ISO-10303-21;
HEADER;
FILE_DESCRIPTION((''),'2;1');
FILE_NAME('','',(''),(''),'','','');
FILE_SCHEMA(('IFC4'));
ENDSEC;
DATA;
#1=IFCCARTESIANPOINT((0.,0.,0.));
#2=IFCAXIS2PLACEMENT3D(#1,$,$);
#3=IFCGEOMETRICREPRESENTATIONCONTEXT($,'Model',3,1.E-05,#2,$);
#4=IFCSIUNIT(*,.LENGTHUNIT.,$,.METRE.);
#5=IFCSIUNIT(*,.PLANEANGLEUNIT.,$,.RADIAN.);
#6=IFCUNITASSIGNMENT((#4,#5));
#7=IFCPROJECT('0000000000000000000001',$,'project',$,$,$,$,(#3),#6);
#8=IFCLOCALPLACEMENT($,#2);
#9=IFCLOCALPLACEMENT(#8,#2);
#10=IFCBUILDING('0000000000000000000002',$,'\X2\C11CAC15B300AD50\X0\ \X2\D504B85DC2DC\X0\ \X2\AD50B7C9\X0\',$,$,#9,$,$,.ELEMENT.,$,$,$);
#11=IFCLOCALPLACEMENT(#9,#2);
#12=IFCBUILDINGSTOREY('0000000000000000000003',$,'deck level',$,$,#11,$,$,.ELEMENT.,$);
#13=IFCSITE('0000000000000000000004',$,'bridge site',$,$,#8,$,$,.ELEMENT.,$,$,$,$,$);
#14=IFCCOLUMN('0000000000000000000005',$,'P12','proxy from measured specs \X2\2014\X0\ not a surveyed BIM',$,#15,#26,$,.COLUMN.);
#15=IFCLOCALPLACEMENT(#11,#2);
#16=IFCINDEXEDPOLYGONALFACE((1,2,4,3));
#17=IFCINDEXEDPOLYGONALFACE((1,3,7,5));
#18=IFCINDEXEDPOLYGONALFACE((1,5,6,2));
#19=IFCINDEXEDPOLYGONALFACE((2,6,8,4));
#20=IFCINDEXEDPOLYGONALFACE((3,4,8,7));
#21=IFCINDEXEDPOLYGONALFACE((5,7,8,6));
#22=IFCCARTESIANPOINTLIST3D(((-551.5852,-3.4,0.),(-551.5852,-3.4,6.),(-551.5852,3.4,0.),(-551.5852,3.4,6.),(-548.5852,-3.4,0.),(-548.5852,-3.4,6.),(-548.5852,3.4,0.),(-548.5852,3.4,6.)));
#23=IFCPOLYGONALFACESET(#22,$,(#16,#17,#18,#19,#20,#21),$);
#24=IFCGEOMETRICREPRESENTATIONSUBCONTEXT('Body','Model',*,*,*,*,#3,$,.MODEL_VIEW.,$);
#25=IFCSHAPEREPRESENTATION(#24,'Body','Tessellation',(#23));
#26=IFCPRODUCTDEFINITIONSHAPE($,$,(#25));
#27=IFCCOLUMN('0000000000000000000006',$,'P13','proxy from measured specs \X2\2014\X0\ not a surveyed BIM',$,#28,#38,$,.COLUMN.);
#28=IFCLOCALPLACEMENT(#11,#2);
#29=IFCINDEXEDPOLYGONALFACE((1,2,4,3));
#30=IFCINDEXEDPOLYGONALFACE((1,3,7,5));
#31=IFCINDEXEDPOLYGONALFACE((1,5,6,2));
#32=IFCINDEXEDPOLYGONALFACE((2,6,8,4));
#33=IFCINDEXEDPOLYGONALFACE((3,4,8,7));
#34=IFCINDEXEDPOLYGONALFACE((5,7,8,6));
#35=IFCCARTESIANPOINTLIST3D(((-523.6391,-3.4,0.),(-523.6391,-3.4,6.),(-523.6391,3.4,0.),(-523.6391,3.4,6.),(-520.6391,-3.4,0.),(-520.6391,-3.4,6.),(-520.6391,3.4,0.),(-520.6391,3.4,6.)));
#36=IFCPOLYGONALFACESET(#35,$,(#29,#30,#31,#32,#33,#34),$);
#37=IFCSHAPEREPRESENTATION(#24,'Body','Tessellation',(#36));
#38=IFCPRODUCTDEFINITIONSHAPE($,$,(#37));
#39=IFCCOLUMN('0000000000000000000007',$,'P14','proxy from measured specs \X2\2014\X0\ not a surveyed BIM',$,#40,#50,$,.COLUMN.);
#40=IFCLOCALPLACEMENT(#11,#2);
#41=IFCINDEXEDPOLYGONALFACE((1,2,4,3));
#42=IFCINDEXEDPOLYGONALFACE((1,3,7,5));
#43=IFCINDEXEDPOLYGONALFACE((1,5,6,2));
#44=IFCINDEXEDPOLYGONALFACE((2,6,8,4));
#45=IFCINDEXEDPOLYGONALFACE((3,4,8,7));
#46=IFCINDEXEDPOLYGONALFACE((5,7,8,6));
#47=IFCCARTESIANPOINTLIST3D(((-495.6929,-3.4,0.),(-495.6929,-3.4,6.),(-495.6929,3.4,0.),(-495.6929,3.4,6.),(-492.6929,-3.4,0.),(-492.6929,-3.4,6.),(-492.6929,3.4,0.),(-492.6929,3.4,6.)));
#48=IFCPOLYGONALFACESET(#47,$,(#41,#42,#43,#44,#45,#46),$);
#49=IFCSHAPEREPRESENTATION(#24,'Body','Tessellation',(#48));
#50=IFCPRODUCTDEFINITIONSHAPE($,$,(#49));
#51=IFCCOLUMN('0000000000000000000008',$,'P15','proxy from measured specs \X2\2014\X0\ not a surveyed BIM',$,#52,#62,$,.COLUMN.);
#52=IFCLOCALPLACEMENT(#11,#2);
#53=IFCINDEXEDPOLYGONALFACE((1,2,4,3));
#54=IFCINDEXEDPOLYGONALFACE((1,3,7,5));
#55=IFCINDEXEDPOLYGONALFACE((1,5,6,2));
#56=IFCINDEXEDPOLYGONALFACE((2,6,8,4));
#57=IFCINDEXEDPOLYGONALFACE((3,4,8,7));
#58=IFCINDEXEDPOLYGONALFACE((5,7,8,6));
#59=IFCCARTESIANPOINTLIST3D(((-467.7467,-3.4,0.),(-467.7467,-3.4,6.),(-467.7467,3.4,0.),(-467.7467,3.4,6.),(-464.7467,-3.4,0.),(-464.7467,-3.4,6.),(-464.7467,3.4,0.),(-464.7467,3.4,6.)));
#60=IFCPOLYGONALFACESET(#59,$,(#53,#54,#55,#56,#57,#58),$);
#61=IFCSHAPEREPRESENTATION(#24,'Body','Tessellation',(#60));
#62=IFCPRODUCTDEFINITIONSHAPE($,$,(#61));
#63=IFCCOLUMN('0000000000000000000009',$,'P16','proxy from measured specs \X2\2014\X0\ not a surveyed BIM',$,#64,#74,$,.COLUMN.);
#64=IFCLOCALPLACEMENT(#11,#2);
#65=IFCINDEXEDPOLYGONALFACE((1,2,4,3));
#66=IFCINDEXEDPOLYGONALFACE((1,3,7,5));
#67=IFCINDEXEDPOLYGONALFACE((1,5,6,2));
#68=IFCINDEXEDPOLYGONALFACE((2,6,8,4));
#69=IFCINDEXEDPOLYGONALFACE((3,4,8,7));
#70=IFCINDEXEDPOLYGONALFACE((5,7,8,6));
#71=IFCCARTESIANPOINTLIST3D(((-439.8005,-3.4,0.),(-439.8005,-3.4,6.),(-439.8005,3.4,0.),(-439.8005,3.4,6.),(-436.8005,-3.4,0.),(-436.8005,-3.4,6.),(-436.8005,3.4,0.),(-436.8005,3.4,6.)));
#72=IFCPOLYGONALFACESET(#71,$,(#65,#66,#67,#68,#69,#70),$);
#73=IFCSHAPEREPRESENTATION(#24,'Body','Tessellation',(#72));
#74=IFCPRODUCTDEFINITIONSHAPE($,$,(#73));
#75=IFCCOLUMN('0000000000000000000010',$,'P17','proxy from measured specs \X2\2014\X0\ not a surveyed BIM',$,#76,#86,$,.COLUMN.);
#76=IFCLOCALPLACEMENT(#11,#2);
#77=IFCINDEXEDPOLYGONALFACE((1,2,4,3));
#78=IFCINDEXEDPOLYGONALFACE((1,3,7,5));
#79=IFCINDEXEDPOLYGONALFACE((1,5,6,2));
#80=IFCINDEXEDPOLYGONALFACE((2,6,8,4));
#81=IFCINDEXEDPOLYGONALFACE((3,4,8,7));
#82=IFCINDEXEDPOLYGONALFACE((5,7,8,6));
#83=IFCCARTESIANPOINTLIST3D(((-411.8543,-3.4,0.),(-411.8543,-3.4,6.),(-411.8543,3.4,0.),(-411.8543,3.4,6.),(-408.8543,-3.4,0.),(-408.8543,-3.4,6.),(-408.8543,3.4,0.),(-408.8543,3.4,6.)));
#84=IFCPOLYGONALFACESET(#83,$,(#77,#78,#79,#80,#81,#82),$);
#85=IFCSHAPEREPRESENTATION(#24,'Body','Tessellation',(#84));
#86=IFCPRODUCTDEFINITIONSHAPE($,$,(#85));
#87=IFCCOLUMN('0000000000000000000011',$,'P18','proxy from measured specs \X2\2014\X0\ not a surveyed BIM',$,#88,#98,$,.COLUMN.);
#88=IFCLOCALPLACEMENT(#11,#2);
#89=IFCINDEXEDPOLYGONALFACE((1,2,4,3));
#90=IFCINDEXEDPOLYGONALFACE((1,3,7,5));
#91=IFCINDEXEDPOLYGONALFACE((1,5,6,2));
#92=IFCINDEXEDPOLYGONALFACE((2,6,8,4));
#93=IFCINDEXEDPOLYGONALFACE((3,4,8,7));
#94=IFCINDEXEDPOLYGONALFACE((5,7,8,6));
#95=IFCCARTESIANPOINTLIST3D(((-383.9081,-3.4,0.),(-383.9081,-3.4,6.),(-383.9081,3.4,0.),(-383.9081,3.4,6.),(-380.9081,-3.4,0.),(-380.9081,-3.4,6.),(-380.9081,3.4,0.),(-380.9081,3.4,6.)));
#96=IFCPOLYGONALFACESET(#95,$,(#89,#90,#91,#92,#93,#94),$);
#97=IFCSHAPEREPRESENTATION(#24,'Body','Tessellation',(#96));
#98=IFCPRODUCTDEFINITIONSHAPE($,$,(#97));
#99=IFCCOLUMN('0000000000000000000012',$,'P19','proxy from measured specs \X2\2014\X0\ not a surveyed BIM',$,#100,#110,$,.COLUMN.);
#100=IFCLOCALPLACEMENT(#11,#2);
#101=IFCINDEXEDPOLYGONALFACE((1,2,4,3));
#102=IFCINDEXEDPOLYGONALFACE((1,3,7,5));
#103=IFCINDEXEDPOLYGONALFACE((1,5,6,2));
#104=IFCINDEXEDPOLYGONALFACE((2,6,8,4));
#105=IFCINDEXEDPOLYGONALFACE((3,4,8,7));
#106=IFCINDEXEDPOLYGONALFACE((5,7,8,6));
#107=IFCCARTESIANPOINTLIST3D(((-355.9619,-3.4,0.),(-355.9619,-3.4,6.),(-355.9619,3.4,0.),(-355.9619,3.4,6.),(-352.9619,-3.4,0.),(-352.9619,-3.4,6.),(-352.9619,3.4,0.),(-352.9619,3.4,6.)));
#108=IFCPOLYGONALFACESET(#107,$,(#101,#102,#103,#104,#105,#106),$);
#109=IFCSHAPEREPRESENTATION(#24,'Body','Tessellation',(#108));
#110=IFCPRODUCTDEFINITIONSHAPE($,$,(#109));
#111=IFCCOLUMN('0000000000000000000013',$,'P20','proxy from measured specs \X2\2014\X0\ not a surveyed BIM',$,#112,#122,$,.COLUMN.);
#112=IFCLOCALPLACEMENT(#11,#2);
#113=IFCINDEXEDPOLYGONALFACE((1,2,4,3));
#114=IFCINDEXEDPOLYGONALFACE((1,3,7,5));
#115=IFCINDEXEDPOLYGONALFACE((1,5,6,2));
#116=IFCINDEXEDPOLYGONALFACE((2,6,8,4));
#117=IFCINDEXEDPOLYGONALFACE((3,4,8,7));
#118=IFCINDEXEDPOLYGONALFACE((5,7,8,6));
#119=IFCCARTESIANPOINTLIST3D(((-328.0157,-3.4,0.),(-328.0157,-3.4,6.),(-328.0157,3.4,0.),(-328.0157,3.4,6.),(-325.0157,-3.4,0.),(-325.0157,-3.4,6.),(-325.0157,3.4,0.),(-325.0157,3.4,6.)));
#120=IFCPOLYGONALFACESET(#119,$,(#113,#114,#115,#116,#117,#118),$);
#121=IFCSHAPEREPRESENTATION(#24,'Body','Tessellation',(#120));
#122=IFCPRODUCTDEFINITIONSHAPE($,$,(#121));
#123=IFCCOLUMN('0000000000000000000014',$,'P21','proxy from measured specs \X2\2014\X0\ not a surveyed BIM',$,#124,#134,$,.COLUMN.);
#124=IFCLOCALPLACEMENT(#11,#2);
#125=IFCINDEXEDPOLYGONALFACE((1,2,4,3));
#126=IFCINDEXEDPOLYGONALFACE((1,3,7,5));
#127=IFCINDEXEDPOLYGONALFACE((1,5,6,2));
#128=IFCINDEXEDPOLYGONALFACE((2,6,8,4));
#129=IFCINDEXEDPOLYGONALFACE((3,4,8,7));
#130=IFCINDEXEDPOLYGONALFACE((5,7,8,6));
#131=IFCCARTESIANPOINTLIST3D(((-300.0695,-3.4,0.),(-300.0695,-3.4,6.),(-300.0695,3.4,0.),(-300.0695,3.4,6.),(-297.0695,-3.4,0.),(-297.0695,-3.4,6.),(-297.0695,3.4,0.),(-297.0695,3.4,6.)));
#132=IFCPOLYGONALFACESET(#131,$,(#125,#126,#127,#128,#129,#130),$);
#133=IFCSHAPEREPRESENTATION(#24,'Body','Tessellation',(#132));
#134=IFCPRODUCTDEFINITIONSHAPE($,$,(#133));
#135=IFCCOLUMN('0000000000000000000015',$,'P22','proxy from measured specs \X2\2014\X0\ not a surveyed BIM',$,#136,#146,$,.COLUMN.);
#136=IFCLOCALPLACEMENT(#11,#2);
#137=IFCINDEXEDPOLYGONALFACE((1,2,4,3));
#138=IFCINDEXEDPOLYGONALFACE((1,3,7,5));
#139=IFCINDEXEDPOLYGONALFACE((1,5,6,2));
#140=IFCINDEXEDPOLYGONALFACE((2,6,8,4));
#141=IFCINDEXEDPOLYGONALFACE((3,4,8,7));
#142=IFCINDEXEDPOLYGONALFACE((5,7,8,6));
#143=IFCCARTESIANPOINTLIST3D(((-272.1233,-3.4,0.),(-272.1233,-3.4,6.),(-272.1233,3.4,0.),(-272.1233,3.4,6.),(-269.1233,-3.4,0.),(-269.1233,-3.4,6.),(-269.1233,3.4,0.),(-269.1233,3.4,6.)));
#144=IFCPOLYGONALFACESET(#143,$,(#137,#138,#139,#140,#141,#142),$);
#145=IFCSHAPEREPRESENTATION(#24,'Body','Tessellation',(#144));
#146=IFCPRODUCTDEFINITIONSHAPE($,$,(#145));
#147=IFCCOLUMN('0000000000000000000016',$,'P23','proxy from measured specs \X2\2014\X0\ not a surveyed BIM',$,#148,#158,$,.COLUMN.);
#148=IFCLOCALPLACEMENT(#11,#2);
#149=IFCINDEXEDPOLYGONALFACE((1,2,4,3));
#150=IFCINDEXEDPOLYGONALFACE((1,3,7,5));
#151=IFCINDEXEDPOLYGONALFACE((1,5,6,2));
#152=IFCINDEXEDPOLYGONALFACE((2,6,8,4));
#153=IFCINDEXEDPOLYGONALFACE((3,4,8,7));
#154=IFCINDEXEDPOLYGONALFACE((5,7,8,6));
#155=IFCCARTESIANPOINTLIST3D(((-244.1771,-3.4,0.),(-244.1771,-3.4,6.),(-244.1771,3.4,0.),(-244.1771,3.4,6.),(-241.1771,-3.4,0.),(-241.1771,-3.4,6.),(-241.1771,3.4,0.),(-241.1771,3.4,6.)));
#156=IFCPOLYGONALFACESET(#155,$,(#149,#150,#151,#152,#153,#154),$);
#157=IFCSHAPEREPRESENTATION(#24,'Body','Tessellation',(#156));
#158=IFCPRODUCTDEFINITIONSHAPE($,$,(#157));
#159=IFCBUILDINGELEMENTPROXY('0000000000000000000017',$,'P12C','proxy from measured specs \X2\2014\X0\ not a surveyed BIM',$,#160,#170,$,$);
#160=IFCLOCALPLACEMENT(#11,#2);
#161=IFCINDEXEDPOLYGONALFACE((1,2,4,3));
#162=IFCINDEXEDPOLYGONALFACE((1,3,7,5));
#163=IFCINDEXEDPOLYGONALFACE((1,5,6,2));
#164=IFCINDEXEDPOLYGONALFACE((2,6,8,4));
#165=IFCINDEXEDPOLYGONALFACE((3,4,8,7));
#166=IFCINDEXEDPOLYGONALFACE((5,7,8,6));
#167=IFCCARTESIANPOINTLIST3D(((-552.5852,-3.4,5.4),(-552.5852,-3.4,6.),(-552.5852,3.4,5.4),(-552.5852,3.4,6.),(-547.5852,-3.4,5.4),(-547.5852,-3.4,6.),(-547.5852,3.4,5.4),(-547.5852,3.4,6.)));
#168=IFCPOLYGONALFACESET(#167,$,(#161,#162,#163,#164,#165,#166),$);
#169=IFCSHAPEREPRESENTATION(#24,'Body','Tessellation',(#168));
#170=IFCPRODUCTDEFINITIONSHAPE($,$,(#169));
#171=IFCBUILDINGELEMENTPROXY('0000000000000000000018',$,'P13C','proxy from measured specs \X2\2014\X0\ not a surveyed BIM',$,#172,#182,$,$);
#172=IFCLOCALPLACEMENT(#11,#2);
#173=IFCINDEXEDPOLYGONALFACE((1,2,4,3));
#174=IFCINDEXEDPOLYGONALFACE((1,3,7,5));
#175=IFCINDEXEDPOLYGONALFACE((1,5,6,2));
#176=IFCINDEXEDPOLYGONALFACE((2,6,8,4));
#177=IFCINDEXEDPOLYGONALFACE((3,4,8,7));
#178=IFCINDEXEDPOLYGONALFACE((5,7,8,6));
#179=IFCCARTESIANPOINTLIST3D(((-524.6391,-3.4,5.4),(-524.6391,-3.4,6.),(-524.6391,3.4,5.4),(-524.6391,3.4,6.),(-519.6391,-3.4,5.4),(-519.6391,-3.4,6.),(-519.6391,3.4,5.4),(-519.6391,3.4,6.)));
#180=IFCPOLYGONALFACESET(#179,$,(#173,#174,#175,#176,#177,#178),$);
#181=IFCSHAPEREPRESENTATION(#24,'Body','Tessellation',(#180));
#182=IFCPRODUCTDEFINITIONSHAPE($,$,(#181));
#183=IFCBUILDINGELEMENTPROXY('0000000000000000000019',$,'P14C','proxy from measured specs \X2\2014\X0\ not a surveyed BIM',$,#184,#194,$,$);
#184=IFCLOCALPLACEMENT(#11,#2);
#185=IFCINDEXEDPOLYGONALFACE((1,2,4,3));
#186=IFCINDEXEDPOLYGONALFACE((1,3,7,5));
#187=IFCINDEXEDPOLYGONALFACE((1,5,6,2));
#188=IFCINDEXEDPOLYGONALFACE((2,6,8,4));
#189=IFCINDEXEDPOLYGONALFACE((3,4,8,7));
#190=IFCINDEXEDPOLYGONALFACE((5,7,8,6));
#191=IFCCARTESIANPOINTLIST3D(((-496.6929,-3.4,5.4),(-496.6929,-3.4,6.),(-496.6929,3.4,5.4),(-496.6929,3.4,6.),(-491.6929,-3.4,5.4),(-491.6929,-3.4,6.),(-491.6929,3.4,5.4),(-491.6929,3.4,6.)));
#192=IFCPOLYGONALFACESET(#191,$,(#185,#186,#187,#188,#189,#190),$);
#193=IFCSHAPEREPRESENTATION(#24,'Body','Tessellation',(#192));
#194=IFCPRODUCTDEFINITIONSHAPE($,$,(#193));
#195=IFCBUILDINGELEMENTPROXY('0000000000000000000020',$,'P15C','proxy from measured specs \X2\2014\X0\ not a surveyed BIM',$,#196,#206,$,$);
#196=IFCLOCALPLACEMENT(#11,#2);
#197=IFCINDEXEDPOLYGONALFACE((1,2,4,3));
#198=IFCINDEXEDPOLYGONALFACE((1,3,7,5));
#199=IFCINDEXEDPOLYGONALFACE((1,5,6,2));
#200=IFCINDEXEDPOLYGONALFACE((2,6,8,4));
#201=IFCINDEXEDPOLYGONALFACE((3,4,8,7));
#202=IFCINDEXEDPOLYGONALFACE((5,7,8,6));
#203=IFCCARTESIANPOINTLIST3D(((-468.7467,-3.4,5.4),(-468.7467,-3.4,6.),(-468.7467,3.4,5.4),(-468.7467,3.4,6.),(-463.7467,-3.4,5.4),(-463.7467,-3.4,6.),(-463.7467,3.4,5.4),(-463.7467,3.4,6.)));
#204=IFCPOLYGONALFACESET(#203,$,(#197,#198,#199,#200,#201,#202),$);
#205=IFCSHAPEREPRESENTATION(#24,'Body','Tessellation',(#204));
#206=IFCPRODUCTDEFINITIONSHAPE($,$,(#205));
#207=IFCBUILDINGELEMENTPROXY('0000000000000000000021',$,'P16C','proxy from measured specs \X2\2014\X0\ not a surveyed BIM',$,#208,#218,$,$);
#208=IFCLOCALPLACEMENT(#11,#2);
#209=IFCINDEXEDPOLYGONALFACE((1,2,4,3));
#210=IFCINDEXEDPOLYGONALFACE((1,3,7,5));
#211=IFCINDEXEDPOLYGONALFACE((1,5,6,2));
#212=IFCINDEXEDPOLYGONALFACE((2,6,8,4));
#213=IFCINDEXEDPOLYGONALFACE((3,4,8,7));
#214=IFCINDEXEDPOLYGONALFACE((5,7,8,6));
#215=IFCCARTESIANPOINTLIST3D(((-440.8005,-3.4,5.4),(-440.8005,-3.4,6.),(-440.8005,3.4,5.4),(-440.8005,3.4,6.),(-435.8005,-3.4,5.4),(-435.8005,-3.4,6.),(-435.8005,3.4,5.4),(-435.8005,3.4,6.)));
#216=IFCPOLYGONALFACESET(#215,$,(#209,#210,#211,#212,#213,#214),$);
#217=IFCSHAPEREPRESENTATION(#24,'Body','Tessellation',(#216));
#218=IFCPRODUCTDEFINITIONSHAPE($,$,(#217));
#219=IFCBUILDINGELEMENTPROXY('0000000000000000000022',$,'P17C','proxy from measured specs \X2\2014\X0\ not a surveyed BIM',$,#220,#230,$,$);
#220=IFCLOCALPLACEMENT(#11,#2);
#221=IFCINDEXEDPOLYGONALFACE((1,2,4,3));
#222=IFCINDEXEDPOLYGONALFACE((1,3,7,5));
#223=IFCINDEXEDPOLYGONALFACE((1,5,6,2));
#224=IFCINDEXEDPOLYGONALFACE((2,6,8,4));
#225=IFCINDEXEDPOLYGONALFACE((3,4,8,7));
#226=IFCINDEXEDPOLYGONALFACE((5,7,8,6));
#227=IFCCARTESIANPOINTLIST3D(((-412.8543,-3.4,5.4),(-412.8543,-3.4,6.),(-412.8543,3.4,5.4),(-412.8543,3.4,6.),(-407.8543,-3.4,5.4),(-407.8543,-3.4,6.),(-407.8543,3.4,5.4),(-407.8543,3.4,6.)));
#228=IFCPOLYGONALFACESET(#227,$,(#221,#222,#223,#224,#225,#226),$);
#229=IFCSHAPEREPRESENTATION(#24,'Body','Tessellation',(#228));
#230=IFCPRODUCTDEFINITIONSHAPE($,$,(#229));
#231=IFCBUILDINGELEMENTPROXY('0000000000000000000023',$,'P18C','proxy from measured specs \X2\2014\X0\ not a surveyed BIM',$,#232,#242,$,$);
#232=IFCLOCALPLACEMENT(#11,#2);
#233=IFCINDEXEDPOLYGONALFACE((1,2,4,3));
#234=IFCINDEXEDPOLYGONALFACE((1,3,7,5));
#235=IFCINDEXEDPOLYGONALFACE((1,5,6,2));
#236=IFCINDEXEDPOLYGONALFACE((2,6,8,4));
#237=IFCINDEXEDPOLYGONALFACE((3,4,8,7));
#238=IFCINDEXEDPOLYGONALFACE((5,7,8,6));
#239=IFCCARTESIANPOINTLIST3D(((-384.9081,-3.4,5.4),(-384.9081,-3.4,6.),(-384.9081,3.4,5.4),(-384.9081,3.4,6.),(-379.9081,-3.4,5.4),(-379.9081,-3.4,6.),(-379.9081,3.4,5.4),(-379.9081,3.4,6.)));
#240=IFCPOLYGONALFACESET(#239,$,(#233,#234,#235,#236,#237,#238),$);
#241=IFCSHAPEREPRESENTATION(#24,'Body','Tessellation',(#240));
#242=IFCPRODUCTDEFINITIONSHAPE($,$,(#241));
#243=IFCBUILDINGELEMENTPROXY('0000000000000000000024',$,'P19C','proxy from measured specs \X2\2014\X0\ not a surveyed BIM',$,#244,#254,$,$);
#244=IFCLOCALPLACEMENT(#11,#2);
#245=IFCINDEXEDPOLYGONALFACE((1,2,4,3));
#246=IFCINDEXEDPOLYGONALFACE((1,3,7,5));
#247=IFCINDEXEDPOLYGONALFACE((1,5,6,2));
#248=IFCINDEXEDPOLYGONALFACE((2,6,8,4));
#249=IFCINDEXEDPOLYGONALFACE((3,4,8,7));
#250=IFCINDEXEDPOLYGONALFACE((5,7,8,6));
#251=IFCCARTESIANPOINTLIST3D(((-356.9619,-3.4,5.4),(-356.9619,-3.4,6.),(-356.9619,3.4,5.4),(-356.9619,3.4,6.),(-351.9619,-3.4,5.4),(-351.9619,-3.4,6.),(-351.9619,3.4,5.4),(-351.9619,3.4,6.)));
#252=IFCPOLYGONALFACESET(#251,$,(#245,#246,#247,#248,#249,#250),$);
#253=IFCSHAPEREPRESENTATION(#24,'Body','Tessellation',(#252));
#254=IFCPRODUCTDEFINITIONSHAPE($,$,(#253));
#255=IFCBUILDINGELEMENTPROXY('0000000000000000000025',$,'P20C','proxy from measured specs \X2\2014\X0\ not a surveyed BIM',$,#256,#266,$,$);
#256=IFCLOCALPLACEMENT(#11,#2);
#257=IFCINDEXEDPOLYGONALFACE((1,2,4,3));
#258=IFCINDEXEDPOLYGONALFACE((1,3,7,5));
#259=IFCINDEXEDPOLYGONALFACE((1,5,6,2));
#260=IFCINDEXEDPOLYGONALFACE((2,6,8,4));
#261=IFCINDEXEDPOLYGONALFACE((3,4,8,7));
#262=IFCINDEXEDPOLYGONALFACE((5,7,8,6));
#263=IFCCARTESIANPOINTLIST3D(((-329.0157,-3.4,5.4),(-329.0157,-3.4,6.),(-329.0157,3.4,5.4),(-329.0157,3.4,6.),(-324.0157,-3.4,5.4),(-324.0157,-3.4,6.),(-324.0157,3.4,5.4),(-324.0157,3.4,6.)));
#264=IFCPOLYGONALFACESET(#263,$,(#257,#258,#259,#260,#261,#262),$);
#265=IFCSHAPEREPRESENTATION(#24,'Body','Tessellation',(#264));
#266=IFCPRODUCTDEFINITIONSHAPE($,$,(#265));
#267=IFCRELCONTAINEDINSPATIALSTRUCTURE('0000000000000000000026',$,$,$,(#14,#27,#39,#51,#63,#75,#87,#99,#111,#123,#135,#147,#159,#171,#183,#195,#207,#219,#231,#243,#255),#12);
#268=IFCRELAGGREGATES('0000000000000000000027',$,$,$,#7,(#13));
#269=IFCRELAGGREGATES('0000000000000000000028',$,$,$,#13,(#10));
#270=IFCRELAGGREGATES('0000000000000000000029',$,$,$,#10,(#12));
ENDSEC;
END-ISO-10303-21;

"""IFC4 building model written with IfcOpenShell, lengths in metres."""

from ifc_helpers import new_model, si_unit, frame, origin, origin_2d, place, context, subcontext, project, spatial, rectangle, extrude, element, save


model = new_model("IFC4")

# Units and contexts
model_context = context("Model", 3, precision=1e-05, world=origin())
body_context = subcontext(model_context, "Body", "Model", "MODEL_VIEW")
ifc_project = project(units=[si_unit("LENGTHUNIT", "METRE"), si_unit("PLANEANGLEUNIT", "RADIAN")], contexts=[model_context])

# Site, building, storey
site_placement = place(None, origin())
site = spatial("IfcSite", under=ifc_project, at=site_placement, Name="bridge site", CompositionType="ELEMENT")
building_placement = place(site_placement, origin())
building = spatial("IfcBuilding", under=site, at=building_placement, Name="서강대교 프록시 교량", CompositionType="ELEMENT")
storey_placement = place(building_placement, origin())
storey = spatial("IfcBuildingStorey", under=building, at=storey_placement, Name="deck level", CompositionType="ELEMENT")

# Columns
for number, where, name in (
    (1, (-550.0852, 0.0, 0.0), "P12"),
    (2, (-522.1391, 0.0, 0.0), "P13"),
    (3, (-494.1929, 0.0, 0.0), "P14"),
    (4, (-466.2467, 0.0, 0.0), "P15"),
    (5, (-438.3005, 0.0, 0.0), "P16"),
    (6, (-410.3543, 0.0, 0.0), "P17"),
    (7, (-382.4081, 0.0, 0.0), "P18"),
    (8, (-354.4619, 0.0, 0.0), "P19"),
    (9, (-326.5157, 0.0, 0.0), "P20"),
    (10, (-298.5695, 0.0, 0.0), "P21"),
    (11, (-270.6233, 0.0, 0.0), "P22"),
    (12, (-242.6771, 0.0, 0.0), "P23"),
):
    element("IfcColumn", number, at=place(storey_placement, frame(where)), inside=storey, Name=name, Description="proxy from measured specs — not a surveyed BIM", PredefinedType="COLUMN", context=body_context, shape_type="SweptSolid", body=[
        extrude(rectangle(XDim=3.0, YDim=6.8, at=origin_2d()), origin(), (0.0, 0.0, 1.0), 6.0),
    ])

# Building element proxies
for number, where, name in (
    (13, (-550.0852, 0.0, 5.4), "P12C"),
    (14, (-522.1391, 0.0, 5.4), "P13C"),
    (15, (-494.1929, 0.0, 5.4), "P14C"),
    (16, (-466.2467, 0.0, 5.4), "P15C"),
    (17, (-438.3005, 0.0, 5.4), "P16C"),
    (18, (-410.3543, 0.0, 5.4), "P17C"),
    (19, (-382.4081, 0.0, 5.4), "P18C"),
    (20, (-354.4619, 0.0, 5.4), "P19C"),
    (21, (-326.5157, 0.0, 5.4), "P20C"),
):
    element("IfcBuildingElementProxy", number, at=place(storey_placement, frame(where)), inside=storey, Name=name, Description="proxy from measured specs — not a surveyed BIM", context=body_context, shape_type="SweptSolid", body=[
        extrude(rectangle(XDim=5.0, YDim=6.8, at=origin_2d()), origin(), (0.0, 0.0, 1.0), 0.6),
    ])

save(model, "model.ifc")
